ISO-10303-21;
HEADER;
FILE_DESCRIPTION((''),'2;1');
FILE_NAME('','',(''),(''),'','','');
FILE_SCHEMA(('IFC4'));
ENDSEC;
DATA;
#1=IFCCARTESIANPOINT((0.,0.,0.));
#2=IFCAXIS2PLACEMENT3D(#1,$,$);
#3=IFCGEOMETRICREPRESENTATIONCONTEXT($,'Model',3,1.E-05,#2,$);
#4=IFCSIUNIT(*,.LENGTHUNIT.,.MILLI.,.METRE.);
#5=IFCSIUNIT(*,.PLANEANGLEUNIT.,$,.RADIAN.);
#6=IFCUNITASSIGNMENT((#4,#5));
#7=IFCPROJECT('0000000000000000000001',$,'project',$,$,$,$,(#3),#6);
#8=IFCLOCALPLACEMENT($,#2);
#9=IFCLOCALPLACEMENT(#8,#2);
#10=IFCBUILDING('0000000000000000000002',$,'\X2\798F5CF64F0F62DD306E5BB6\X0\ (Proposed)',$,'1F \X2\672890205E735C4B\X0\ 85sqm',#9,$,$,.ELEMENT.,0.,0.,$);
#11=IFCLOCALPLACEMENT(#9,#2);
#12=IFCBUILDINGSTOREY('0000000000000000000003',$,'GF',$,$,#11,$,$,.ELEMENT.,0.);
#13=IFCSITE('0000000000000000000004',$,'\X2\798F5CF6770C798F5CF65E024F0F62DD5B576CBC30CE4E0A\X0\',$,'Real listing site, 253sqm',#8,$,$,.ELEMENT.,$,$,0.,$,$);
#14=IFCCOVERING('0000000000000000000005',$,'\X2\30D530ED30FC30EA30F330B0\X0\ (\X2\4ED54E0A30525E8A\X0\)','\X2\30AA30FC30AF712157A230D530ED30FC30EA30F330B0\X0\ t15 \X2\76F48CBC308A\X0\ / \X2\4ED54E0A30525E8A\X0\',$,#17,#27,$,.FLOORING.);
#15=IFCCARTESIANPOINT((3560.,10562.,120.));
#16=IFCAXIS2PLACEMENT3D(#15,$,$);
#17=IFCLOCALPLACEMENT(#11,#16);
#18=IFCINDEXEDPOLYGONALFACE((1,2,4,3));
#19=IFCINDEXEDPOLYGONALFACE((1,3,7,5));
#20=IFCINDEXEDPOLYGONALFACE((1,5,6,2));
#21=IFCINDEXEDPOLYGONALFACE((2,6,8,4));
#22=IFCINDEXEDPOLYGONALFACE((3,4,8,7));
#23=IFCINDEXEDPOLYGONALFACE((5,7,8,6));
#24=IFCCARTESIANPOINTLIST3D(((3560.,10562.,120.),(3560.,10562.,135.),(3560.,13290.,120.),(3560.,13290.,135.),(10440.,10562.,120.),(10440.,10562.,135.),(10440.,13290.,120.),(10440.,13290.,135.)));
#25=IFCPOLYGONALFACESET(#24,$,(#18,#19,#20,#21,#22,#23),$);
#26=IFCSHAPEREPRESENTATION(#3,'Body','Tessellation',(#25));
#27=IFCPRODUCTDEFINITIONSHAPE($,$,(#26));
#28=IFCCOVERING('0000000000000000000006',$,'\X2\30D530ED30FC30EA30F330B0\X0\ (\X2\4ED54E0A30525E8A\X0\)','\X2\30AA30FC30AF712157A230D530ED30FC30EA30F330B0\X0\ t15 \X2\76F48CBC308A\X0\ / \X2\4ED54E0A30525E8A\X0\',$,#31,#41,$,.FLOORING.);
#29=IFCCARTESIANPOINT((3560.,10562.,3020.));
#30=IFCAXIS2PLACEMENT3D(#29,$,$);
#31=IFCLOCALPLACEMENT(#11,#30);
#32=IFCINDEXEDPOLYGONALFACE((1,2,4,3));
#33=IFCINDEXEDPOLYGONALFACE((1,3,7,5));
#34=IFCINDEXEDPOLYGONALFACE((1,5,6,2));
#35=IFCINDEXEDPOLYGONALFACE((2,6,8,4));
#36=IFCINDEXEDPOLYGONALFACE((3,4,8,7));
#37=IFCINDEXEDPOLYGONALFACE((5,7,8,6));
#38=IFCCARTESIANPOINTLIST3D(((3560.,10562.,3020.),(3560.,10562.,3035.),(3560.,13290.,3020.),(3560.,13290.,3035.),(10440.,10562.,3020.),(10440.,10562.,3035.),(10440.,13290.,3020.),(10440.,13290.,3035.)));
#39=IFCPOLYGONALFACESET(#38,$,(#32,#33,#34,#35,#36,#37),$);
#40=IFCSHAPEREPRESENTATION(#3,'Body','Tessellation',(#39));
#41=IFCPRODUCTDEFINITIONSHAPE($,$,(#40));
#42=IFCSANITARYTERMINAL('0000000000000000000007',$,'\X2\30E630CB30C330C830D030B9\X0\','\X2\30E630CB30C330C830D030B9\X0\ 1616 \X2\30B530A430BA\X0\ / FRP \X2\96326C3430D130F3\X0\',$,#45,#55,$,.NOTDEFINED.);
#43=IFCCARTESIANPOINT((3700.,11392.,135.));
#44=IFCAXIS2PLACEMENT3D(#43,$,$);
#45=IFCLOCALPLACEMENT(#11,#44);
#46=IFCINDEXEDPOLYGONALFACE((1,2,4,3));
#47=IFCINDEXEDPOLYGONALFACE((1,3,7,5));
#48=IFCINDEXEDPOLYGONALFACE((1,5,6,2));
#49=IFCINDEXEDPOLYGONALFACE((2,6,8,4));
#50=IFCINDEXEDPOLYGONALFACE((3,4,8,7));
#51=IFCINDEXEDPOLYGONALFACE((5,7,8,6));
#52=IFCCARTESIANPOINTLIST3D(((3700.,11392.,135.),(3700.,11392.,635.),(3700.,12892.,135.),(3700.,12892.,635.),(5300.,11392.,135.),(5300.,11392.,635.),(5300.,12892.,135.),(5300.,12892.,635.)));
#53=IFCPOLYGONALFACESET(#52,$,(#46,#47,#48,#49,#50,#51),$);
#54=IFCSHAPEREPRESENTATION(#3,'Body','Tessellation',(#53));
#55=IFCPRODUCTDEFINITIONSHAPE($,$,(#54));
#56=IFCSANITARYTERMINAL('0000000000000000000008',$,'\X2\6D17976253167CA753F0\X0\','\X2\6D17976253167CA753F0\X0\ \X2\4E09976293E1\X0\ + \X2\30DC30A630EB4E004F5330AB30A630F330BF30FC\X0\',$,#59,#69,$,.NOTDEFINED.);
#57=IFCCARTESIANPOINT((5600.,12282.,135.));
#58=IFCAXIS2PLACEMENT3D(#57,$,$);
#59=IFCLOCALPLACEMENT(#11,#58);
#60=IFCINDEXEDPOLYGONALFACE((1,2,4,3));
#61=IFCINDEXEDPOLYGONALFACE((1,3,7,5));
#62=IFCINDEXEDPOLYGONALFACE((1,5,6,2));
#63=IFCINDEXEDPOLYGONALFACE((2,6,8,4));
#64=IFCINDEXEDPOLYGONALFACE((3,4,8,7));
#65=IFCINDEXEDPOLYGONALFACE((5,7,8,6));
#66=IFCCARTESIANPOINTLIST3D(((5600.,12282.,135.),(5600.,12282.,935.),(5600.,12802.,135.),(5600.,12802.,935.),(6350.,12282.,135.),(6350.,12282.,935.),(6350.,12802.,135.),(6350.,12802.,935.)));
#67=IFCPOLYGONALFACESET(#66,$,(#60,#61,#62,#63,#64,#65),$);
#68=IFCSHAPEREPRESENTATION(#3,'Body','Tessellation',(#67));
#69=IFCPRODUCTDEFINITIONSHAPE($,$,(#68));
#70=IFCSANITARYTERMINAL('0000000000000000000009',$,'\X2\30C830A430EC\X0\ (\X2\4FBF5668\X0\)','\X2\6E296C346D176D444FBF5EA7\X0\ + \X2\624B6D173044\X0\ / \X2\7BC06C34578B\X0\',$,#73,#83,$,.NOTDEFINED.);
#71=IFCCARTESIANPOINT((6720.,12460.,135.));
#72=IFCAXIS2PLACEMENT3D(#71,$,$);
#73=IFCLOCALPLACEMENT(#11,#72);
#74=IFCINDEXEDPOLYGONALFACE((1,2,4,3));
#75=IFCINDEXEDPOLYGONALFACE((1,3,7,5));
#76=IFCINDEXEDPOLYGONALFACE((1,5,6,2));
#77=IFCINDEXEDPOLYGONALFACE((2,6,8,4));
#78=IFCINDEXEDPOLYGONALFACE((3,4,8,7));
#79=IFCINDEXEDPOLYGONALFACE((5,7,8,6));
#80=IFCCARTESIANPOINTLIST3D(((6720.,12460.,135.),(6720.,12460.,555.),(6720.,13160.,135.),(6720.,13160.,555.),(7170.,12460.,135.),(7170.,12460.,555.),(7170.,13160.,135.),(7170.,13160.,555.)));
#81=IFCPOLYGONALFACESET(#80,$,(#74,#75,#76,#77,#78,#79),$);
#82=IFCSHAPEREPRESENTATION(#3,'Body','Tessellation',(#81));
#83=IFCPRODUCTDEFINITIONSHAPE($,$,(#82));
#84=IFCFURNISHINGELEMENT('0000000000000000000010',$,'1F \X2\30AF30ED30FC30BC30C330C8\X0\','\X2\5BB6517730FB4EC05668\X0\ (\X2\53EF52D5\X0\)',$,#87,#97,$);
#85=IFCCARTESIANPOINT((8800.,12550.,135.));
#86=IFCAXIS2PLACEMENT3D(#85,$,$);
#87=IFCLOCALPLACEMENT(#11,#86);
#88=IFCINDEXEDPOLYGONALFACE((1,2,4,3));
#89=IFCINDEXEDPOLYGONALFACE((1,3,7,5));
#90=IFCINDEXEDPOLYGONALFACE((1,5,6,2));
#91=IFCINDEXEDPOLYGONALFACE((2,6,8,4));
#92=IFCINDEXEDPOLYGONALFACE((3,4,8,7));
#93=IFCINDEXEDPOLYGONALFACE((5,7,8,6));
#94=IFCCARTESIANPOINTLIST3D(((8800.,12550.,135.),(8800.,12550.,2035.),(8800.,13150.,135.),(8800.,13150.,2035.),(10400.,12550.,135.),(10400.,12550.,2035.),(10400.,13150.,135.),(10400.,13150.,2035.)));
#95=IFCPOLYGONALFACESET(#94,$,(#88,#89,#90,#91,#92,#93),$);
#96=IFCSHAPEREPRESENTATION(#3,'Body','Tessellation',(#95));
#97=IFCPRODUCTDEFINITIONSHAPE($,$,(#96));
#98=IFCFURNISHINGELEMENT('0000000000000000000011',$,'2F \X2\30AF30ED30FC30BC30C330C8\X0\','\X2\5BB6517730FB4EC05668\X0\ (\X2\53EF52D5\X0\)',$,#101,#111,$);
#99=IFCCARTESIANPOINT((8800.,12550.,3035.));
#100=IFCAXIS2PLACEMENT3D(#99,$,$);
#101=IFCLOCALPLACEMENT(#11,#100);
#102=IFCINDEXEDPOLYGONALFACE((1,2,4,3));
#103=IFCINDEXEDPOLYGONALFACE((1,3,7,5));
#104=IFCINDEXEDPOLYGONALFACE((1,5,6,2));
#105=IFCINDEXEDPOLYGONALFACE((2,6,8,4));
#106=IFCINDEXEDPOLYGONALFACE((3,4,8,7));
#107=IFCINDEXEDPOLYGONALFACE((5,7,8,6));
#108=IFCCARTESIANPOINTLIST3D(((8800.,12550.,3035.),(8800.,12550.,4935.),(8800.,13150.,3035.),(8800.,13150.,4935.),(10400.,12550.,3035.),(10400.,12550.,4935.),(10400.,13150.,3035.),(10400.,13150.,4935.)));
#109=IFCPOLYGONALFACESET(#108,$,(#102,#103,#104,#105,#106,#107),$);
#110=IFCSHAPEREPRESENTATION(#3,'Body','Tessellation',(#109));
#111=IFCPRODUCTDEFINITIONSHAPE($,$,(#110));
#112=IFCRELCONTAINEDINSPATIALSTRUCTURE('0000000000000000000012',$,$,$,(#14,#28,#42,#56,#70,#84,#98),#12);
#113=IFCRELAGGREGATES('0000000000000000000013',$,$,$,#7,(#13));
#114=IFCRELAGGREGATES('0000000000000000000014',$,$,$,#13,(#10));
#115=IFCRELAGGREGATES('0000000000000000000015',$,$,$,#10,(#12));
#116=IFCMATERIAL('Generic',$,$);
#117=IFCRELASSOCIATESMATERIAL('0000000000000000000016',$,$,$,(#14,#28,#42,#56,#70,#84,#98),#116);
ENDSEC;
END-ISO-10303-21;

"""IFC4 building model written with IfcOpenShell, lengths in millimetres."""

from ifc_helpers import new_model, si_unit, frame, frame_2d, origin, place, context, project, spatial, rectangle, extrude, material, element, save


model = new_model("IFC4")

# Units and contexts
model_context = context("Model", 3, precision=1e-05, world=origin())
ifc_project = project(units=[si_unit("LENGTHUNIT", "METRE", prefix="MILLI"), si_unit("PLANEANGLEUNIT", "RADIAN")], contexts=[model_context])

# Site, building, storey
site_placement = place(None, origin())
site = spatial("IfcSite", under=ifc_project, at=site_placement, Name="福島県福島市伏拝字沼ノ上", ObjectType="Real listing site, 253sqm", CompositionType="ELEMENT", RefElevation=0.0)
building_placement = place(site_placement, origin())
building = spatial("IfcBuilding", under=site, at=building_placement, Name="福島伏拝の家 (Proposed)", ObjectType="1F 木造平屋 85sqm", CompositionType="ELEMENT", ElevationOfRefHeight=0.0, ElevationOfTerrain=0.0)
storey_placement = place(building_placement, origin())
storey = spatial("IfcBuildingStorey", under=building, at=storey_placement, Name="GF", CompositionType="ELEMENT", Elevation=0.0)

# Coverings
ifc_material_1 = material(Name="Generic")
covering_1_placement = place(storey_placement, frame((3560.0, 10562.0, 120.0)))
element("IfcCovering", 1, at=covering_1_placement, inside=storey, material=ifc_material_1, Name="フローリング (仕上げ床)", Description="オーク無垢フローリング t15 直貼り / 仕上げ床", PredefinedType="FLOORING", context=model_context, shape_type="SweptSolid", body=[
    extrude(rectangle(XDim=6880.0, YDim=2728.0, at=frame_2d((3440.0, 1364.0))), frame((3560.0, 10562.0, 120.0)), (0.0, 0.0, 1.0), 15.0),
])
covering_2_placement = place(storey_placement, frame((3560.0, 10562.0, 3020.0)))
element("IfcCovering", 2, at=covering_2_placement, inside=storey, material=ifc_material_1, Name="フローリング (仕上げ床)", Description="オーク無垢フローリング t15 直貼り / 仕上げ床", PredefinedType="FLOORING", context=model_context, shape_type="SweptSolid", body=[
    extrude(rectangle(XDim=6880.0, YDim=2728.0, at=frame_2d((3440.0, 1364.0))), frame((3560.0, 10562.0, 3020.0)), (0.0, 0.0, 1.0), 15.0),
])

# Sanitary terminals
sanitary_terminal_1_placement = place(storey_placement, frame((3700.0, 11392.0, 135.0)))
element("IfcSanitaryTerminal", 3, at=sanitary_terminal_1_placement, inside=storey, material=ifc_material_1, Name="ユニットバス", Description="ユニットバス 1616 サイズ / FRP 防水パン", PredefinedType="NOTDEFINED", context=model_context, shape_type="SweptSolid", body=[
    extrude(rectangle(XDim=1600.0, YDim=1500.0, at=frame_2d((800.0, 750.0))), frame((3700.0, 11392.0, 135.0)), (0.0, 0.0, 1.0), 500.0),
])
sanitary_terminal_2_placement = place(storey_placement, frame((5600.0, 12282.0, 135.0)))
element("IfcSanitaryTerminal", 4, at=sanitary_terminal_2_placement, inside=storey, material=ifc_material_1, Name="洗面化粧台", Description="洗面化粧台 三面鏡 + ボウル一体カウンター", PredefinedType="NOTDEFINED", context=model_context, shape_type="SweptSolid", body=[
    extrude(rectangle(XDim=750.0, YDim=520.0, at=frame_2d((375.0, 260.0))), frame((5600.0, 12282.0, 135.0)), (0.0, 0.0, 1.0), 800.0),
])
sanitary_terminal_3_placement = place(storey_placement, frame((6720.0, 12460.0, 135.0)))
element("IfcSanitaryTerminal", 5, at=sanitary_terminal_3_placement, inside=storey, material=ifc_material_1, Name="トイレ (便器)", Description="温水洗浄便座 + 手洗い / 節水型", PredefinedType="NOTDEFINED", context=model_context, shape_type="SweptSolid", body=[
    extrude(rectangle(XDim=450.0, YDim=700.0, at=frame_2d((225.0, 350.0))), frame((6720.0, 12460.0, 135.0)), (0.0, 0.0, 1.0), 420.0),
])

# Furnishing elements
furnishing_1_placement = place(storey_placement, frame((8800.0, 12550.0, 135.0)))
element("IfcFurnishingElement", 6, at=furnishing_1_placement, inside=storey, material=ifc_material_1, Name="1F クローゼット", Description="家具・什器 (可動)", context=model_context, shape_type="SweptSolid", body=[
    extrude(rectangle(XDim=1600.0, YDim=600.0, at=frame_2d((800.0, 300.0))), frame((8800.0, 12550.0, 135.0)), (0.0, 0.0, 1.0), 1900.0),
])
furnishing_2_placement = place(storey_placement, frame((8800.0, 12550.0, 3035.0)))
element("IfcFurnishingElement", 7, at=furnishing_2_placement, inside=storey, material=ifc_material_1, Name="2F クローゼット", Description="家具・什器 (可動)", context=model_context, shape_type="SweptSolid", body=[
    extrude(rectangle(XDim=1600.0, YDim=600.0, at=frame_2d((800.0, 300.0))), frame((8800.0, 12550.0, 3035.0)), (0.0, 0.0, 1.0), 1900.0),
])

save(model, "model.ifc")
